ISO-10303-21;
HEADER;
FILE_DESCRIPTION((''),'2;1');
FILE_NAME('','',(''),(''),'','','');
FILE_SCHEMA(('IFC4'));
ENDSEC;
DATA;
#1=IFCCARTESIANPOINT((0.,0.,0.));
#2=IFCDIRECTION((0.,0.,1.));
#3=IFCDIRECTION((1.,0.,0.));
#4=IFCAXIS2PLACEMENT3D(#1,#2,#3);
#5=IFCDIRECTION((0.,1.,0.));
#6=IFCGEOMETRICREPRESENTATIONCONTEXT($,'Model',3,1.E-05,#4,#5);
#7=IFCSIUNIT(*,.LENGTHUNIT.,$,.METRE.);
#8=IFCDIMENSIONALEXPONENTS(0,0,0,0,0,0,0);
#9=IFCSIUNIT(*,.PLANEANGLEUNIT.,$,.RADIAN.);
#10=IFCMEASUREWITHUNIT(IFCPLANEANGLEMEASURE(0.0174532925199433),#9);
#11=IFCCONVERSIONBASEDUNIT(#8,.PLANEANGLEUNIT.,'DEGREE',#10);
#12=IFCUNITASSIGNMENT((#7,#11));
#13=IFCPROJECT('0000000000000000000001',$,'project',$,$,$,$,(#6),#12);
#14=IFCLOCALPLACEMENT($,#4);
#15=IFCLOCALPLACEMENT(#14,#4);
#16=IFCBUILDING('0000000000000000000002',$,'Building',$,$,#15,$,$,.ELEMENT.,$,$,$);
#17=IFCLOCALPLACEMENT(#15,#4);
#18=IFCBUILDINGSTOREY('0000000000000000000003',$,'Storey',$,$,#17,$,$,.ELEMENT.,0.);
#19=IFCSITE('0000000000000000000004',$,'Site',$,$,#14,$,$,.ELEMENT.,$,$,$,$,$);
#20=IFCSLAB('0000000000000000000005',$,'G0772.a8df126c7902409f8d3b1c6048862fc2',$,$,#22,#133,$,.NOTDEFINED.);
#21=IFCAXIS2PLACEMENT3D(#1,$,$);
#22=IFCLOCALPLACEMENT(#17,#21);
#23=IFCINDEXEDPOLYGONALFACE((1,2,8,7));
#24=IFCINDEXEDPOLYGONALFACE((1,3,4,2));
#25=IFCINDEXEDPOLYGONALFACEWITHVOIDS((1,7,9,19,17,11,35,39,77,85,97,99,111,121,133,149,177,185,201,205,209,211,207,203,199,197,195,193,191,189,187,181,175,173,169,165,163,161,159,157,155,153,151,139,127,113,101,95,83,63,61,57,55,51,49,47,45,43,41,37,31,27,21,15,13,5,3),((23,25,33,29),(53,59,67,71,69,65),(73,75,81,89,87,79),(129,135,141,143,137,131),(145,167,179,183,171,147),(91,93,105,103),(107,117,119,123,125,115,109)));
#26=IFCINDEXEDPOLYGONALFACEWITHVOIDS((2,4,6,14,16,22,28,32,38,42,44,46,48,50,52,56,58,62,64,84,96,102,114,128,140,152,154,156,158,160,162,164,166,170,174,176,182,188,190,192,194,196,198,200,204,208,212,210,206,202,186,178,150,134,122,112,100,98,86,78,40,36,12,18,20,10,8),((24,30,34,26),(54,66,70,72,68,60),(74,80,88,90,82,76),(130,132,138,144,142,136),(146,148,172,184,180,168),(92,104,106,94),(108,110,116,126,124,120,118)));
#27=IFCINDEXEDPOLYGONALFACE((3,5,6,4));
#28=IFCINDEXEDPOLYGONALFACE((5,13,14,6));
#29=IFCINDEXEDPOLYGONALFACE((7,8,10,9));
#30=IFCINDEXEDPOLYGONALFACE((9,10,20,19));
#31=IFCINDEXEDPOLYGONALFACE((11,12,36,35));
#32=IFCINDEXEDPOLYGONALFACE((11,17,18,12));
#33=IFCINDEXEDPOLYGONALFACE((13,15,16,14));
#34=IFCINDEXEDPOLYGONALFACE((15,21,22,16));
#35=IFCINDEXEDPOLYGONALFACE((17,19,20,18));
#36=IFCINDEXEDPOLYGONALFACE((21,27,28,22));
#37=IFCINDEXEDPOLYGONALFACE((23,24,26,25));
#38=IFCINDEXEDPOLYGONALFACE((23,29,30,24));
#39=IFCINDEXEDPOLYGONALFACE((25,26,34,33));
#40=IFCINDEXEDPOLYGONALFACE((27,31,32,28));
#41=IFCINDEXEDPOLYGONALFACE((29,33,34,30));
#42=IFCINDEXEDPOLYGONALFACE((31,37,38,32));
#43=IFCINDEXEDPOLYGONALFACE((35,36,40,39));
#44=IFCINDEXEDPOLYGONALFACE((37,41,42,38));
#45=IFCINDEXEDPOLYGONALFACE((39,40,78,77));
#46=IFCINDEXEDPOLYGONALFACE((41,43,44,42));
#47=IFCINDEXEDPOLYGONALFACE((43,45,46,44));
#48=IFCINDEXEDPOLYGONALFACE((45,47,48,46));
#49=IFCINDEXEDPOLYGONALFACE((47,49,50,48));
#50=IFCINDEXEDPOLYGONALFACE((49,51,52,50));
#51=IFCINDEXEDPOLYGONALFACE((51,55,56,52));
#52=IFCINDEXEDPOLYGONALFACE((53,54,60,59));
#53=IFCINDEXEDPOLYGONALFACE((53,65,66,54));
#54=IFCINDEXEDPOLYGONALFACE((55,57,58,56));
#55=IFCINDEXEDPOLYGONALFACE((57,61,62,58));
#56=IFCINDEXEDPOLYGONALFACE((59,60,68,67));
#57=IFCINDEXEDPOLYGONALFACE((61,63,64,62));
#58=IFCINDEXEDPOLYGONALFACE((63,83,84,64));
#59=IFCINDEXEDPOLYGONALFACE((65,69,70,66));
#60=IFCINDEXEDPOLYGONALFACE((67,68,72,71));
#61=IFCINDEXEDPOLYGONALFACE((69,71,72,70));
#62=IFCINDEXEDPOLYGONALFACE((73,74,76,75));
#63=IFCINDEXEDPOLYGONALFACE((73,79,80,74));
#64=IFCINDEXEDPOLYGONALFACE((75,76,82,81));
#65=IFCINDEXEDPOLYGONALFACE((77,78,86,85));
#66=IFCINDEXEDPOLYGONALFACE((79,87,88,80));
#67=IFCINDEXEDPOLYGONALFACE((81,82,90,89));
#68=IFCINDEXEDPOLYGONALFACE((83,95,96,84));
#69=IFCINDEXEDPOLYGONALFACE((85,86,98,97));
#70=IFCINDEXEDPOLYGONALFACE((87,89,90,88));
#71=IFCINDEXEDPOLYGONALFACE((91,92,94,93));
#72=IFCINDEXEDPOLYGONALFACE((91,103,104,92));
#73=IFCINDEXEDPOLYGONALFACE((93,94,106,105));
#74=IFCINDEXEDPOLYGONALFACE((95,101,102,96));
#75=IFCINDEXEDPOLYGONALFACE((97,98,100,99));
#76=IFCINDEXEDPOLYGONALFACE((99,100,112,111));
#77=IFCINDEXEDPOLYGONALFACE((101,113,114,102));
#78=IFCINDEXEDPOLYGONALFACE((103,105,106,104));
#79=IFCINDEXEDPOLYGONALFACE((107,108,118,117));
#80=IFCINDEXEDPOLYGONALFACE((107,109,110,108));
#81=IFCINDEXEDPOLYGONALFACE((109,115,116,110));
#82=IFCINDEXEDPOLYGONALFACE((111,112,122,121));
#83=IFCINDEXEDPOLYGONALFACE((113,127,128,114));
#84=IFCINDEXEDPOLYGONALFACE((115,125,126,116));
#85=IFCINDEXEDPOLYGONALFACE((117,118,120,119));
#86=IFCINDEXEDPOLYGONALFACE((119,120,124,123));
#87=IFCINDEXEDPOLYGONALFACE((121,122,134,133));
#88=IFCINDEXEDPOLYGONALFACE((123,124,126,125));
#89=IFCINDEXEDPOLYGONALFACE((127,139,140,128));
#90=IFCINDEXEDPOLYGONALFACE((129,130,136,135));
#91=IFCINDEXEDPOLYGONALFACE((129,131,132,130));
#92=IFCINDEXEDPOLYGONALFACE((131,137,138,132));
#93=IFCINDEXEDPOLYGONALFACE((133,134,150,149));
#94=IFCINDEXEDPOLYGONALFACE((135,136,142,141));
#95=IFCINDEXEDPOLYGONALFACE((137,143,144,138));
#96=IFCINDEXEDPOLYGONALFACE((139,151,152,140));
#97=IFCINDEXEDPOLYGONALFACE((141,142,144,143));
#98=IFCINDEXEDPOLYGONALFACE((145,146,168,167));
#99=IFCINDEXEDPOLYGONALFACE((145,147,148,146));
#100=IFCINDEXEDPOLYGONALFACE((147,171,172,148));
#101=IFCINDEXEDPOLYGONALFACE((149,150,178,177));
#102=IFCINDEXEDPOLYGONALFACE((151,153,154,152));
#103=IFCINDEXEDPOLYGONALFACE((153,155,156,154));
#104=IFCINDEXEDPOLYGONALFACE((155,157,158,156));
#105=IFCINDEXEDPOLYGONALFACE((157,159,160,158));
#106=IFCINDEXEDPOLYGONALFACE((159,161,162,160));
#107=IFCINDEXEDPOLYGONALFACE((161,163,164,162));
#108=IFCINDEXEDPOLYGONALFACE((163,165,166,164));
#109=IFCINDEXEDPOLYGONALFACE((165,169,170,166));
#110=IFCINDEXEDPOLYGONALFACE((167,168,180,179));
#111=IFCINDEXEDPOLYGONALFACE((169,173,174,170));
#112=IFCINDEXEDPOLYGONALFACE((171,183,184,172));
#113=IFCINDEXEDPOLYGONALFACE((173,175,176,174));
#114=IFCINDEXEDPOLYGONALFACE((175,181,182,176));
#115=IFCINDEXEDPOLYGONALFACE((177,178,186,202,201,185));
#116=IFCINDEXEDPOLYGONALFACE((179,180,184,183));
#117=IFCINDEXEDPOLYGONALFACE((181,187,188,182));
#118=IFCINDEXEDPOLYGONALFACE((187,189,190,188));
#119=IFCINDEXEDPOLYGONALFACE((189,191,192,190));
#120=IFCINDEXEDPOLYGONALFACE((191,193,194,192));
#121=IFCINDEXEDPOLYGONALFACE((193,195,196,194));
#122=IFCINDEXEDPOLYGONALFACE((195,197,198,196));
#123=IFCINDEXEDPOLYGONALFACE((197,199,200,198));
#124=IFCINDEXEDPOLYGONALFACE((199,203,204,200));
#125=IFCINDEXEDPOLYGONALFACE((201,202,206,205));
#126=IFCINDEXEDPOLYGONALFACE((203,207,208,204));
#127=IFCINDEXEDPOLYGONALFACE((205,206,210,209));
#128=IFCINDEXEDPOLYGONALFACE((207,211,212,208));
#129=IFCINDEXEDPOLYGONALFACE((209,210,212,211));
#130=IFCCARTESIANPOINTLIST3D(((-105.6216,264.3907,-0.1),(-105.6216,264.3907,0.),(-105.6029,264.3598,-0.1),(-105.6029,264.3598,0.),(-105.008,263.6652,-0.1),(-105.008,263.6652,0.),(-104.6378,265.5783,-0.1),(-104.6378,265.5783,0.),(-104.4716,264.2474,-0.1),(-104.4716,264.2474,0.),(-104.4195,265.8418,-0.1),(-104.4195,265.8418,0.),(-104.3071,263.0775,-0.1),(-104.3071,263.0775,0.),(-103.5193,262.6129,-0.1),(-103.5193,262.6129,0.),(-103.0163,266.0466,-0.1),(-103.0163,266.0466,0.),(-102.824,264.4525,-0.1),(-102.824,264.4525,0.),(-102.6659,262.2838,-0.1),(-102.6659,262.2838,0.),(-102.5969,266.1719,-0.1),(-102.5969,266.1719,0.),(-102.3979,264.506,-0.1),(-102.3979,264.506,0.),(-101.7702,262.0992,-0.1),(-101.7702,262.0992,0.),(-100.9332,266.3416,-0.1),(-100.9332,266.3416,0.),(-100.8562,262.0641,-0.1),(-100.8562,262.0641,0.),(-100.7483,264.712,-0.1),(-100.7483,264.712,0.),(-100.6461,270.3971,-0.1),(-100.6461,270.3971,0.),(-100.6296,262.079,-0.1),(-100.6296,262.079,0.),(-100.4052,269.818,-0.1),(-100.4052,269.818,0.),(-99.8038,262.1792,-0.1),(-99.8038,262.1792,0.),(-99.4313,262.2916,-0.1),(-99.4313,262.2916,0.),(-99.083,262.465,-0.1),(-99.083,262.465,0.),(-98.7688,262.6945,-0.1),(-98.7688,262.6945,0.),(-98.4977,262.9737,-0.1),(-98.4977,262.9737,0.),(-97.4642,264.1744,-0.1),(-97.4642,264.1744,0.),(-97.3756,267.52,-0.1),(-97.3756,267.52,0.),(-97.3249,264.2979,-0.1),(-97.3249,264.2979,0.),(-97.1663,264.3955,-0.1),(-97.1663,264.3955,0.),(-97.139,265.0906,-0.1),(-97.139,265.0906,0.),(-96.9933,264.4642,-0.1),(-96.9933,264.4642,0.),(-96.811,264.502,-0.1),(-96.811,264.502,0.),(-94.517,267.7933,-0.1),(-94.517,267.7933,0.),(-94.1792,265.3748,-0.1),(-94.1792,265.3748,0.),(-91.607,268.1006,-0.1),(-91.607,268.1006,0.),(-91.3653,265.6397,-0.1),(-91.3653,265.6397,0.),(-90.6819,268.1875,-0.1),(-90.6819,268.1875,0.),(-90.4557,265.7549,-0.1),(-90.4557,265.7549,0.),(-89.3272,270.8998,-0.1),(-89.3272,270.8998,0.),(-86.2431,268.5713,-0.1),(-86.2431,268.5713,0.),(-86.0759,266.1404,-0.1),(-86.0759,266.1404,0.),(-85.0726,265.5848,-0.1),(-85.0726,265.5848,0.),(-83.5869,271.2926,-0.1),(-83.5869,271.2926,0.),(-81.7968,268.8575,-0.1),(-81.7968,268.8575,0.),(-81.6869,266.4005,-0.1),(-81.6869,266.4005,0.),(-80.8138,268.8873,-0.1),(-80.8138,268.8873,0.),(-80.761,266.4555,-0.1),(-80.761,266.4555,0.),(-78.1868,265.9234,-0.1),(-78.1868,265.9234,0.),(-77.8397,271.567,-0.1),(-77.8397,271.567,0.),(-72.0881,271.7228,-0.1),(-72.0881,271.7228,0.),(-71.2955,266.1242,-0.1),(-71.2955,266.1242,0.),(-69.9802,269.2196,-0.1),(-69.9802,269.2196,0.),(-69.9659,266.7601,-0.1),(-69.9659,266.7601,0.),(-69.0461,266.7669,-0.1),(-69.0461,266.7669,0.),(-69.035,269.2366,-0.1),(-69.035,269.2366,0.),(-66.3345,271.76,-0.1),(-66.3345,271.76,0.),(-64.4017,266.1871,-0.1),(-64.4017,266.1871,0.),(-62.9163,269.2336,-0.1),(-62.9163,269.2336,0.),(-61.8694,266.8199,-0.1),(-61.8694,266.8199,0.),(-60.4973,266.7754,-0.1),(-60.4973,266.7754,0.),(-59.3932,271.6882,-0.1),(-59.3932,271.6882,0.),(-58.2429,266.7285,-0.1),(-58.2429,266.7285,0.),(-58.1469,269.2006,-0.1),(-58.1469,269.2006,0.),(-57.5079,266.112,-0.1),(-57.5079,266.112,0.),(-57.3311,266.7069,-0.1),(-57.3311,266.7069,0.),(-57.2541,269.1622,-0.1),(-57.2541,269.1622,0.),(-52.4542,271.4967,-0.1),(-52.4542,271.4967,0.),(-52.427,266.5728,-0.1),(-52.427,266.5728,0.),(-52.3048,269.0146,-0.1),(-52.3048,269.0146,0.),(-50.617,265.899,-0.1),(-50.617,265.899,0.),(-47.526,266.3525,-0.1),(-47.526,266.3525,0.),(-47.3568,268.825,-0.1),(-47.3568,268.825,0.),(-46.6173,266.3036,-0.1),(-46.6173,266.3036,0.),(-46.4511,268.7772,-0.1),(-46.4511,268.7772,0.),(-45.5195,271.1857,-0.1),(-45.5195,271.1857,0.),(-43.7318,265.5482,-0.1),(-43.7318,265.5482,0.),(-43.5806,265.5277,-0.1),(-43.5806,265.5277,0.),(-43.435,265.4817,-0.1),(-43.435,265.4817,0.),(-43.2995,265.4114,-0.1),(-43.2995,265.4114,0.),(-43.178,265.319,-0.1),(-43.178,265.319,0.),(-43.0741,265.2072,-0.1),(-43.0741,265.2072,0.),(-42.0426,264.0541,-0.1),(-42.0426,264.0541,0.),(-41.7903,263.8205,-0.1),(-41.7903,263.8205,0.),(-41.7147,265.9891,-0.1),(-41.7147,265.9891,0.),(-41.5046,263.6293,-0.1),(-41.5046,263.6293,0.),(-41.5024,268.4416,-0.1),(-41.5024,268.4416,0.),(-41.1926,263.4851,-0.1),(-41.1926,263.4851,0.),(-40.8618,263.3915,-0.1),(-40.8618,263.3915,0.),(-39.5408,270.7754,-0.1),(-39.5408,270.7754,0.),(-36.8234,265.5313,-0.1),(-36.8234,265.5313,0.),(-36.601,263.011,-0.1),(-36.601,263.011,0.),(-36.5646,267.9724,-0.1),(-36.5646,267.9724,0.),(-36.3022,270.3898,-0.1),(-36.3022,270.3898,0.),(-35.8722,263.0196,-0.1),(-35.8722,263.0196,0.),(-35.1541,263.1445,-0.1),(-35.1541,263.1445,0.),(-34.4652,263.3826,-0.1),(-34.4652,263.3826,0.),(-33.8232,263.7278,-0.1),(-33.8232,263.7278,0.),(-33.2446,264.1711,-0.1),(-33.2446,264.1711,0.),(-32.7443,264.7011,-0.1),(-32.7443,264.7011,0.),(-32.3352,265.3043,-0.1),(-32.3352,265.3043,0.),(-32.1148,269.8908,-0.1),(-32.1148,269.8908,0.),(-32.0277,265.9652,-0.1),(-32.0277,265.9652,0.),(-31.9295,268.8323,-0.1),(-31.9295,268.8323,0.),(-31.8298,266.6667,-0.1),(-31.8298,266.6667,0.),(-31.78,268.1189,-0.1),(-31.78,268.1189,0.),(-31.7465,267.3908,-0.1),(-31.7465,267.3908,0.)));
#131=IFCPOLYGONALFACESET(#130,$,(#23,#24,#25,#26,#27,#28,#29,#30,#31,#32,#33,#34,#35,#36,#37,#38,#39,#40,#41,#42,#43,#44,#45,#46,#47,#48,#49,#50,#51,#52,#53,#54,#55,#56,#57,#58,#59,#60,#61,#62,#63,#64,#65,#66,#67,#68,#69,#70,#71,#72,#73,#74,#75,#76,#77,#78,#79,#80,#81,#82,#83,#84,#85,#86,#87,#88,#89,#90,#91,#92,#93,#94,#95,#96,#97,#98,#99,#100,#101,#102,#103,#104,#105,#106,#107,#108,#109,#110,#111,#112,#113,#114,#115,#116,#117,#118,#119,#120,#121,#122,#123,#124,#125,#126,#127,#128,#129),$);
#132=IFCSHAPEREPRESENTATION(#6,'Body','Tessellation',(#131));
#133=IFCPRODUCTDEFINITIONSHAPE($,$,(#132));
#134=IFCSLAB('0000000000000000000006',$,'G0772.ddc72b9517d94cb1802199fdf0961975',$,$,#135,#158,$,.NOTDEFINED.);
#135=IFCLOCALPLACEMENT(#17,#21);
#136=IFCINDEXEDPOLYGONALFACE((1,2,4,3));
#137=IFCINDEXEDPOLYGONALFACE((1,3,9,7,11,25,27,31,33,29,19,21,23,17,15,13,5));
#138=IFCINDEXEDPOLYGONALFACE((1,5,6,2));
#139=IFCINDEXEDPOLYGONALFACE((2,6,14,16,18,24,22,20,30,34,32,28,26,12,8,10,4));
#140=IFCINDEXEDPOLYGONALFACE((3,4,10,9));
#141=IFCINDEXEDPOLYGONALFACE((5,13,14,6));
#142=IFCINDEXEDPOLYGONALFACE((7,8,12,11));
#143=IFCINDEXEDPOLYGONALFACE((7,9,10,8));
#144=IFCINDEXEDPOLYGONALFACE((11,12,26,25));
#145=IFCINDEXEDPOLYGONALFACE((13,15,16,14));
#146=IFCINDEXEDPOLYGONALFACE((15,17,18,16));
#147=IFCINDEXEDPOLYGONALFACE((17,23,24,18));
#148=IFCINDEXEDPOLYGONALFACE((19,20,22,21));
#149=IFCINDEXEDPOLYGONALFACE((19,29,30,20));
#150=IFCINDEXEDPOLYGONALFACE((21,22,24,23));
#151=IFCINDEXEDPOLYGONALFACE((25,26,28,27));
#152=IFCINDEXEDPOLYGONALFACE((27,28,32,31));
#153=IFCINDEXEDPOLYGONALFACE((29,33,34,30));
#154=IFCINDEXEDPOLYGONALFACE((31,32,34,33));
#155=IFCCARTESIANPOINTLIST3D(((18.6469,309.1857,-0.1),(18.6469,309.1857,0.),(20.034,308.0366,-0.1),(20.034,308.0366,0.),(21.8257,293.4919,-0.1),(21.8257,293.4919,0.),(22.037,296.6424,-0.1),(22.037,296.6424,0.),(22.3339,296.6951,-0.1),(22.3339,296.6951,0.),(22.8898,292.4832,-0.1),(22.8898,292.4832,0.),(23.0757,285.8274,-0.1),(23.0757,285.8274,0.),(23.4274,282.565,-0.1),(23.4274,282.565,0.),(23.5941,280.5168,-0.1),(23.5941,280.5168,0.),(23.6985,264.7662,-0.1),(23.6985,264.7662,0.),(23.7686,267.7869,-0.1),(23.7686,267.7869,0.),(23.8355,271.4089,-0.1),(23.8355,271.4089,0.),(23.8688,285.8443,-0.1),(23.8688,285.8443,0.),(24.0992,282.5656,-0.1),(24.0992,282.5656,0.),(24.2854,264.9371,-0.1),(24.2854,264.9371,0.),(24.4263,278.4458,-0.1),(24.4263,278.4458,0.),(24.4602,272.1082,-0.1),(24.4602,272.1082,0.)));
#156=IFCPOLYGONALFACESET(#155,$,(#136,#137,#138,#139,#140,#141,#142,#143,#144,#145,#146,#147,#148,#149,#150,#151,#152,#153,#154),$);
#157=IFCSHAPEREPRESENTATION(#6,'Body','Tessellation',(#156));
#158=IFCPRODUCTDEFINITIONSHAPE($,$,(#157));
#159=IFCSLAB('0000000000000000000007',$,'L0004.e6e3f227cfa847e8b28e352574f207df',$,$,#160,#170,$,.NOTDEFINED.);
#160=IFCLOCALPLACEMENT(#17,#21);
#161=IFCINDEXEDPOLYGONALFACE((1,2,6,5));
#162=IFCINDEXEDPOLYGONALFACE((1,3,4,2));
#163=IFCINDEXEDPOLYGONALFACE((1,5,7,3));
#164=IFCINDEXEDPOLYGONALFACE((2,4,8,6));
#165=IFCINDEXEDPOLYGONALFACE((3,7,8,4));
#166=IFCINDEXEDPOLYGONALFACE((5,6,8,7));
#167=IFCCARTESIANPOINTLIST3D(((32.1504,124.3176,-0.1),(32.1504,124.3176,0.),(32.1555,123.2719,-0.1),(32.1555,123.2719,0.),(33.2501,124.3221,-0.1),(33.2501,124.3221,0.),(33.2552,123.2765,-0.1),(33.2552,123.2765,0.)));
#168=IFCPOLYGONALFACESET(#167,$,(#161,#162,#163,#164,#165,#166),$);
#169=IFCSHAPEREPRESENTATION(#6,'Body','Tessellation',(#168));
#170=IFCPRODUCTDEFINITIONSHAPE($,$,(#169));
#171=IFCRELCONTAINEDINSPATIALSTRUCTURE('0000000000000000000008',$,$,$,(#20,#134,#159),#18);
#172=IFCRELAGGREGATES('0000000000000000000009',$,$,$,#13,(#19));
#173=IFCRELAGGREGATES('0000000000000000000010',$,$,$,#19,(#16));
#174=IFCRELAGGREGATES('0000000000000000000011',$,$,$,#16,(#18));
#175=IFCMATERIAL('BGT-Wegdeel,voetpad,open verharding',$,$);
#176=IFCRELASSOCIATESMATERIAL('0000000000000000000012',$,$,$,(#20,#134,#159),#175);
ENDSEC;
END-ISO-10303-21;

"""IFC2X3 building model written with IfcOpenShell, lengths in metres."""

from ifc_helpers import new_model, entity, si_unit, converted_unit, direction, frame, origin_with_axes, place, context, project, spatial, polyline, outline, extrude, material, element, save


model = new_model("IFC2X3")

# Units and contexts
model_context = context("Model", 3, precision=1e-05, world=origin_with_axes(), true_north=direction((0.0, 1.0, 0.0)))
ifc_project = project(units=[si_unit("LENGTHUNIT", "METRE"), converted_unit("PLANEANGLEUNIT", "DEGREE", entity("IfcPlaneAngleMeasure", 0.0174532925199433), si_unit("PLANEANGLEUNIT", "RADIAN"), dimensions=[0, 0, 0, 0, 0, 0, 0])], contexts=[model_context])

# Site, building, storey
site_placement = place(None, origin_with_axes())
site = spatial("IfcSite", under=ifc_project, at=site_placement, Name="Site", CompositionType="ELEMENT")
building_placement = place(site_placement, origin_with_axes())
building = spatial("IfcBuilding", under=site, at=building_placement, Name="Building", CompositionType="ELEMENT")
storey_placement = place(building_placement, origin_with_axes())
storey = spatial("IfcBuildingStorey", under=building, at=storey_placement, Name="Storey", CompositionType="ELEMENT", Elevation=0.0)

# Slabs
ifc_material_1 = material(Name="BGT-Wegdeel,voetpad,open verharding")
slab_1_placement = place(storey_placement, frame((0.0, 0.0, -0.1), z_axis=(0.0, 0.0, 1.0), x_axis=(1.0, 0.0, 0.0)))
element("IfcSlab", 1, at=slab_1_placement, inside=storey, material=ifc_material_1, Name="G0772.a8df126c7902409f8d3b1c6048862fc2", PredefinedType="NOTDEFINED", context=model_context, shape_type="SweptSolid", body=[
    extrude(outline(polyline([(-100.4052, 269.818), (-89.3272, 270.8998), (-83.5869, 271.2926), (-77.8397, 271.567), (-72.0881, 271.7228), (-66.3345, 271.76), (-59.3932, 271.6882), (-52.4542, 271.4967), (-45.5195, 271.1857), (-39.5408, 270.7754), (-36.3022, 270.3898), (-32.1148, 269.8908), (-31.9295, 268.8323), (-31.78, 268.1189), (-31.7465, 267.3908), (-31.8298, 266.6667), (-32.0277, 265.9652), (-32.3352, 265.3043), (-32.7443, 264.7011), (-33.2446, 264.1711), (-33.8232, 263.7278), (-34.4652, 263.3826), (-35.1541, 263.1445), (-35.8722, 263.0196), (-36.601, 263.011), (-40.8618, 263.3915), (-41.1926, 263.4851), (-41.5046, 263.6293), (-41.7903, 263.8205), (-42.0426, 264.0541), (-43.0741, 265.2072), (-43.178, 265.319), (-43.2995, 265.4114), (-43.435, 265.4817), (-43.5806, 265.5277), (-43.7318, 265.5482), (-50.617, 265.899), (-57.5079, 266.112), (-64.4017, 266.1871), (-71.2955, 266.1242), (-78.1868, 265.9234), (-85.0726, 265.5848), (-96.811, 264.502), (-96.9933, 264.4642), (-97.1663, 264.3955), (-97.3249, 264.2979), (-97.4642, 264.1744), (-98.4977, 262.9737), (-98.7688, 262.6945), (-99.083, 262.465), (-99.4313, 262.2916), (-99.8038, 262.1792), (-100.6296, 262.079), (-100.8562, 262.0641), (-101.7702, 262.0992), (-102.6659, 262.2838), (-103.5193, 262.6129), (-104.3071, 263.0775), (-105.008, 263.6652), (-105.6029, 264.3598), (-105.6216, 264.3907), (-104.6378, 265.5783), (-104.4716, 264.2474), (-102.824, 264.4525), (-103.0163, 266.0466), (-104.4195, 265.8418), (-100.6461, 270.3971), (-100.4052, 269.818)]), holes=[polyline([(-100.9332, 266.3416), (-102.5969, 266.1719), (-102.3979, 264.506), (-100.7483, 264.712), (-100.9332, 266.3416)]), polyline([(-91.607, 268.1006), (-94.517, 267.7933), (-97.3756, 267.52), (-97.139, 265.0906), (-94.1792, 265.3748), (-91.3653, 265.6397), (-91.607, 268.1006)]), polyline([(-81.7968, 268.8575), (-86.2431, 268.5713), (-90.6819, 268.1875), (-90.4557, 265.7549), (-86.0759, 266.1404), (-81.6869, 266.4005), (-81.7968, 268.8575)]), polyline([(-69.9802, 269.2196), (-80.8138, 268.8873), (-80.761, 266.4555), (-69.9659, 266.7601), (-69.9802, 269.2196)]), polyline([(-46.6173, 266.3036), (-41.7147, 265.9891), (-36.8234, 265.5313), (-36.5646, 267.9724), (-41.5024, 268.4416), (-46.4511, 268.7772), (-46.6173, 266.3036)]), polyline([(-57.3311, 266.7069), (-52.427, 266.5728), (-47.526, 266.3525), (-47.3568, 268.825), (-52.3048, 269.0146), (-57.2541, 269.1622), (-57.3311, 266.7069)]), polyline([(-69.0461, 266.7669), (-61.8694, 266.8199), (-60.4973, 266.7754), (-58.2429, 266.7285), (-58.1469, 269.2006), (-62.9163, 269.2336), (-69.035, 269.2366), (-69.0461, 266.7669)])]), origin_with_axes(), (0.0, 0.0, 1.0), 0.1),
])
slab_2_placement = place(storey_placement, frame((0.0, 0.0, -0.1), z_axis=(0.0, 0.0, 1.0), x_axis=(1.0, 0.0, 0.0)))
element("IfcSlab", 2, at=slab_2_placement, inside=storey, material=ifc_material_1, Name="G0772.ddc72b9517d94cb1802199fdf0961975", PredefinedType="NOTDEFINED", context=model_context, shape_type="SweptSolid", body=[
    extrude(outline(polyline([(22.3339, 296.6951), (22.037, 296.6424), (22.8898, 292.4832), (23.8688, 285.8443), (24.0992, 282.5656), (24.4263, 278.4458), (24.4602, 272.1082), (24.2854, 264.9371), (23.6985, 264.7662), (23.7686, 267.7869), (23.8355, 271.4089), (23.5941, 280.5168), (23.4274, 282.565), (23.0757, 285.8274), (21.8257, 293.4919), (18.6469, 309.1857), (20.034, 308.0366), (22.3339, 296.6951)])), origin_with_axes(), (0.0, 0.0, 1.0), 0.1),
])
slab_3_placement = place(storey_placement, frame((0.0, 0.0, -0.1), z_axis=(0.0, 0.0, 1.0), x_axis=(1.0, 0.0, 0.0)))
element("IfcSlab", 3, at=slab_3_placement, inside=storey, material=ifc_material_1, Name="L0004.e6e3f227cfa847e8b28e352574f207df", PredefinedType="NOTDEFINED", context=model_context, shape_type="SweptSolid", body=[
    extrude(outline(polyline([(33.2501, 124.3221), (33.2552, 123.2765), (32.1555, 123.2719), (32.1504, 124.3176), (33.2501, 124.3221)])), origin_with_axes(), (0.0, 0.0, 1.0), 0.1),
])

save(model, "model.ifc")
